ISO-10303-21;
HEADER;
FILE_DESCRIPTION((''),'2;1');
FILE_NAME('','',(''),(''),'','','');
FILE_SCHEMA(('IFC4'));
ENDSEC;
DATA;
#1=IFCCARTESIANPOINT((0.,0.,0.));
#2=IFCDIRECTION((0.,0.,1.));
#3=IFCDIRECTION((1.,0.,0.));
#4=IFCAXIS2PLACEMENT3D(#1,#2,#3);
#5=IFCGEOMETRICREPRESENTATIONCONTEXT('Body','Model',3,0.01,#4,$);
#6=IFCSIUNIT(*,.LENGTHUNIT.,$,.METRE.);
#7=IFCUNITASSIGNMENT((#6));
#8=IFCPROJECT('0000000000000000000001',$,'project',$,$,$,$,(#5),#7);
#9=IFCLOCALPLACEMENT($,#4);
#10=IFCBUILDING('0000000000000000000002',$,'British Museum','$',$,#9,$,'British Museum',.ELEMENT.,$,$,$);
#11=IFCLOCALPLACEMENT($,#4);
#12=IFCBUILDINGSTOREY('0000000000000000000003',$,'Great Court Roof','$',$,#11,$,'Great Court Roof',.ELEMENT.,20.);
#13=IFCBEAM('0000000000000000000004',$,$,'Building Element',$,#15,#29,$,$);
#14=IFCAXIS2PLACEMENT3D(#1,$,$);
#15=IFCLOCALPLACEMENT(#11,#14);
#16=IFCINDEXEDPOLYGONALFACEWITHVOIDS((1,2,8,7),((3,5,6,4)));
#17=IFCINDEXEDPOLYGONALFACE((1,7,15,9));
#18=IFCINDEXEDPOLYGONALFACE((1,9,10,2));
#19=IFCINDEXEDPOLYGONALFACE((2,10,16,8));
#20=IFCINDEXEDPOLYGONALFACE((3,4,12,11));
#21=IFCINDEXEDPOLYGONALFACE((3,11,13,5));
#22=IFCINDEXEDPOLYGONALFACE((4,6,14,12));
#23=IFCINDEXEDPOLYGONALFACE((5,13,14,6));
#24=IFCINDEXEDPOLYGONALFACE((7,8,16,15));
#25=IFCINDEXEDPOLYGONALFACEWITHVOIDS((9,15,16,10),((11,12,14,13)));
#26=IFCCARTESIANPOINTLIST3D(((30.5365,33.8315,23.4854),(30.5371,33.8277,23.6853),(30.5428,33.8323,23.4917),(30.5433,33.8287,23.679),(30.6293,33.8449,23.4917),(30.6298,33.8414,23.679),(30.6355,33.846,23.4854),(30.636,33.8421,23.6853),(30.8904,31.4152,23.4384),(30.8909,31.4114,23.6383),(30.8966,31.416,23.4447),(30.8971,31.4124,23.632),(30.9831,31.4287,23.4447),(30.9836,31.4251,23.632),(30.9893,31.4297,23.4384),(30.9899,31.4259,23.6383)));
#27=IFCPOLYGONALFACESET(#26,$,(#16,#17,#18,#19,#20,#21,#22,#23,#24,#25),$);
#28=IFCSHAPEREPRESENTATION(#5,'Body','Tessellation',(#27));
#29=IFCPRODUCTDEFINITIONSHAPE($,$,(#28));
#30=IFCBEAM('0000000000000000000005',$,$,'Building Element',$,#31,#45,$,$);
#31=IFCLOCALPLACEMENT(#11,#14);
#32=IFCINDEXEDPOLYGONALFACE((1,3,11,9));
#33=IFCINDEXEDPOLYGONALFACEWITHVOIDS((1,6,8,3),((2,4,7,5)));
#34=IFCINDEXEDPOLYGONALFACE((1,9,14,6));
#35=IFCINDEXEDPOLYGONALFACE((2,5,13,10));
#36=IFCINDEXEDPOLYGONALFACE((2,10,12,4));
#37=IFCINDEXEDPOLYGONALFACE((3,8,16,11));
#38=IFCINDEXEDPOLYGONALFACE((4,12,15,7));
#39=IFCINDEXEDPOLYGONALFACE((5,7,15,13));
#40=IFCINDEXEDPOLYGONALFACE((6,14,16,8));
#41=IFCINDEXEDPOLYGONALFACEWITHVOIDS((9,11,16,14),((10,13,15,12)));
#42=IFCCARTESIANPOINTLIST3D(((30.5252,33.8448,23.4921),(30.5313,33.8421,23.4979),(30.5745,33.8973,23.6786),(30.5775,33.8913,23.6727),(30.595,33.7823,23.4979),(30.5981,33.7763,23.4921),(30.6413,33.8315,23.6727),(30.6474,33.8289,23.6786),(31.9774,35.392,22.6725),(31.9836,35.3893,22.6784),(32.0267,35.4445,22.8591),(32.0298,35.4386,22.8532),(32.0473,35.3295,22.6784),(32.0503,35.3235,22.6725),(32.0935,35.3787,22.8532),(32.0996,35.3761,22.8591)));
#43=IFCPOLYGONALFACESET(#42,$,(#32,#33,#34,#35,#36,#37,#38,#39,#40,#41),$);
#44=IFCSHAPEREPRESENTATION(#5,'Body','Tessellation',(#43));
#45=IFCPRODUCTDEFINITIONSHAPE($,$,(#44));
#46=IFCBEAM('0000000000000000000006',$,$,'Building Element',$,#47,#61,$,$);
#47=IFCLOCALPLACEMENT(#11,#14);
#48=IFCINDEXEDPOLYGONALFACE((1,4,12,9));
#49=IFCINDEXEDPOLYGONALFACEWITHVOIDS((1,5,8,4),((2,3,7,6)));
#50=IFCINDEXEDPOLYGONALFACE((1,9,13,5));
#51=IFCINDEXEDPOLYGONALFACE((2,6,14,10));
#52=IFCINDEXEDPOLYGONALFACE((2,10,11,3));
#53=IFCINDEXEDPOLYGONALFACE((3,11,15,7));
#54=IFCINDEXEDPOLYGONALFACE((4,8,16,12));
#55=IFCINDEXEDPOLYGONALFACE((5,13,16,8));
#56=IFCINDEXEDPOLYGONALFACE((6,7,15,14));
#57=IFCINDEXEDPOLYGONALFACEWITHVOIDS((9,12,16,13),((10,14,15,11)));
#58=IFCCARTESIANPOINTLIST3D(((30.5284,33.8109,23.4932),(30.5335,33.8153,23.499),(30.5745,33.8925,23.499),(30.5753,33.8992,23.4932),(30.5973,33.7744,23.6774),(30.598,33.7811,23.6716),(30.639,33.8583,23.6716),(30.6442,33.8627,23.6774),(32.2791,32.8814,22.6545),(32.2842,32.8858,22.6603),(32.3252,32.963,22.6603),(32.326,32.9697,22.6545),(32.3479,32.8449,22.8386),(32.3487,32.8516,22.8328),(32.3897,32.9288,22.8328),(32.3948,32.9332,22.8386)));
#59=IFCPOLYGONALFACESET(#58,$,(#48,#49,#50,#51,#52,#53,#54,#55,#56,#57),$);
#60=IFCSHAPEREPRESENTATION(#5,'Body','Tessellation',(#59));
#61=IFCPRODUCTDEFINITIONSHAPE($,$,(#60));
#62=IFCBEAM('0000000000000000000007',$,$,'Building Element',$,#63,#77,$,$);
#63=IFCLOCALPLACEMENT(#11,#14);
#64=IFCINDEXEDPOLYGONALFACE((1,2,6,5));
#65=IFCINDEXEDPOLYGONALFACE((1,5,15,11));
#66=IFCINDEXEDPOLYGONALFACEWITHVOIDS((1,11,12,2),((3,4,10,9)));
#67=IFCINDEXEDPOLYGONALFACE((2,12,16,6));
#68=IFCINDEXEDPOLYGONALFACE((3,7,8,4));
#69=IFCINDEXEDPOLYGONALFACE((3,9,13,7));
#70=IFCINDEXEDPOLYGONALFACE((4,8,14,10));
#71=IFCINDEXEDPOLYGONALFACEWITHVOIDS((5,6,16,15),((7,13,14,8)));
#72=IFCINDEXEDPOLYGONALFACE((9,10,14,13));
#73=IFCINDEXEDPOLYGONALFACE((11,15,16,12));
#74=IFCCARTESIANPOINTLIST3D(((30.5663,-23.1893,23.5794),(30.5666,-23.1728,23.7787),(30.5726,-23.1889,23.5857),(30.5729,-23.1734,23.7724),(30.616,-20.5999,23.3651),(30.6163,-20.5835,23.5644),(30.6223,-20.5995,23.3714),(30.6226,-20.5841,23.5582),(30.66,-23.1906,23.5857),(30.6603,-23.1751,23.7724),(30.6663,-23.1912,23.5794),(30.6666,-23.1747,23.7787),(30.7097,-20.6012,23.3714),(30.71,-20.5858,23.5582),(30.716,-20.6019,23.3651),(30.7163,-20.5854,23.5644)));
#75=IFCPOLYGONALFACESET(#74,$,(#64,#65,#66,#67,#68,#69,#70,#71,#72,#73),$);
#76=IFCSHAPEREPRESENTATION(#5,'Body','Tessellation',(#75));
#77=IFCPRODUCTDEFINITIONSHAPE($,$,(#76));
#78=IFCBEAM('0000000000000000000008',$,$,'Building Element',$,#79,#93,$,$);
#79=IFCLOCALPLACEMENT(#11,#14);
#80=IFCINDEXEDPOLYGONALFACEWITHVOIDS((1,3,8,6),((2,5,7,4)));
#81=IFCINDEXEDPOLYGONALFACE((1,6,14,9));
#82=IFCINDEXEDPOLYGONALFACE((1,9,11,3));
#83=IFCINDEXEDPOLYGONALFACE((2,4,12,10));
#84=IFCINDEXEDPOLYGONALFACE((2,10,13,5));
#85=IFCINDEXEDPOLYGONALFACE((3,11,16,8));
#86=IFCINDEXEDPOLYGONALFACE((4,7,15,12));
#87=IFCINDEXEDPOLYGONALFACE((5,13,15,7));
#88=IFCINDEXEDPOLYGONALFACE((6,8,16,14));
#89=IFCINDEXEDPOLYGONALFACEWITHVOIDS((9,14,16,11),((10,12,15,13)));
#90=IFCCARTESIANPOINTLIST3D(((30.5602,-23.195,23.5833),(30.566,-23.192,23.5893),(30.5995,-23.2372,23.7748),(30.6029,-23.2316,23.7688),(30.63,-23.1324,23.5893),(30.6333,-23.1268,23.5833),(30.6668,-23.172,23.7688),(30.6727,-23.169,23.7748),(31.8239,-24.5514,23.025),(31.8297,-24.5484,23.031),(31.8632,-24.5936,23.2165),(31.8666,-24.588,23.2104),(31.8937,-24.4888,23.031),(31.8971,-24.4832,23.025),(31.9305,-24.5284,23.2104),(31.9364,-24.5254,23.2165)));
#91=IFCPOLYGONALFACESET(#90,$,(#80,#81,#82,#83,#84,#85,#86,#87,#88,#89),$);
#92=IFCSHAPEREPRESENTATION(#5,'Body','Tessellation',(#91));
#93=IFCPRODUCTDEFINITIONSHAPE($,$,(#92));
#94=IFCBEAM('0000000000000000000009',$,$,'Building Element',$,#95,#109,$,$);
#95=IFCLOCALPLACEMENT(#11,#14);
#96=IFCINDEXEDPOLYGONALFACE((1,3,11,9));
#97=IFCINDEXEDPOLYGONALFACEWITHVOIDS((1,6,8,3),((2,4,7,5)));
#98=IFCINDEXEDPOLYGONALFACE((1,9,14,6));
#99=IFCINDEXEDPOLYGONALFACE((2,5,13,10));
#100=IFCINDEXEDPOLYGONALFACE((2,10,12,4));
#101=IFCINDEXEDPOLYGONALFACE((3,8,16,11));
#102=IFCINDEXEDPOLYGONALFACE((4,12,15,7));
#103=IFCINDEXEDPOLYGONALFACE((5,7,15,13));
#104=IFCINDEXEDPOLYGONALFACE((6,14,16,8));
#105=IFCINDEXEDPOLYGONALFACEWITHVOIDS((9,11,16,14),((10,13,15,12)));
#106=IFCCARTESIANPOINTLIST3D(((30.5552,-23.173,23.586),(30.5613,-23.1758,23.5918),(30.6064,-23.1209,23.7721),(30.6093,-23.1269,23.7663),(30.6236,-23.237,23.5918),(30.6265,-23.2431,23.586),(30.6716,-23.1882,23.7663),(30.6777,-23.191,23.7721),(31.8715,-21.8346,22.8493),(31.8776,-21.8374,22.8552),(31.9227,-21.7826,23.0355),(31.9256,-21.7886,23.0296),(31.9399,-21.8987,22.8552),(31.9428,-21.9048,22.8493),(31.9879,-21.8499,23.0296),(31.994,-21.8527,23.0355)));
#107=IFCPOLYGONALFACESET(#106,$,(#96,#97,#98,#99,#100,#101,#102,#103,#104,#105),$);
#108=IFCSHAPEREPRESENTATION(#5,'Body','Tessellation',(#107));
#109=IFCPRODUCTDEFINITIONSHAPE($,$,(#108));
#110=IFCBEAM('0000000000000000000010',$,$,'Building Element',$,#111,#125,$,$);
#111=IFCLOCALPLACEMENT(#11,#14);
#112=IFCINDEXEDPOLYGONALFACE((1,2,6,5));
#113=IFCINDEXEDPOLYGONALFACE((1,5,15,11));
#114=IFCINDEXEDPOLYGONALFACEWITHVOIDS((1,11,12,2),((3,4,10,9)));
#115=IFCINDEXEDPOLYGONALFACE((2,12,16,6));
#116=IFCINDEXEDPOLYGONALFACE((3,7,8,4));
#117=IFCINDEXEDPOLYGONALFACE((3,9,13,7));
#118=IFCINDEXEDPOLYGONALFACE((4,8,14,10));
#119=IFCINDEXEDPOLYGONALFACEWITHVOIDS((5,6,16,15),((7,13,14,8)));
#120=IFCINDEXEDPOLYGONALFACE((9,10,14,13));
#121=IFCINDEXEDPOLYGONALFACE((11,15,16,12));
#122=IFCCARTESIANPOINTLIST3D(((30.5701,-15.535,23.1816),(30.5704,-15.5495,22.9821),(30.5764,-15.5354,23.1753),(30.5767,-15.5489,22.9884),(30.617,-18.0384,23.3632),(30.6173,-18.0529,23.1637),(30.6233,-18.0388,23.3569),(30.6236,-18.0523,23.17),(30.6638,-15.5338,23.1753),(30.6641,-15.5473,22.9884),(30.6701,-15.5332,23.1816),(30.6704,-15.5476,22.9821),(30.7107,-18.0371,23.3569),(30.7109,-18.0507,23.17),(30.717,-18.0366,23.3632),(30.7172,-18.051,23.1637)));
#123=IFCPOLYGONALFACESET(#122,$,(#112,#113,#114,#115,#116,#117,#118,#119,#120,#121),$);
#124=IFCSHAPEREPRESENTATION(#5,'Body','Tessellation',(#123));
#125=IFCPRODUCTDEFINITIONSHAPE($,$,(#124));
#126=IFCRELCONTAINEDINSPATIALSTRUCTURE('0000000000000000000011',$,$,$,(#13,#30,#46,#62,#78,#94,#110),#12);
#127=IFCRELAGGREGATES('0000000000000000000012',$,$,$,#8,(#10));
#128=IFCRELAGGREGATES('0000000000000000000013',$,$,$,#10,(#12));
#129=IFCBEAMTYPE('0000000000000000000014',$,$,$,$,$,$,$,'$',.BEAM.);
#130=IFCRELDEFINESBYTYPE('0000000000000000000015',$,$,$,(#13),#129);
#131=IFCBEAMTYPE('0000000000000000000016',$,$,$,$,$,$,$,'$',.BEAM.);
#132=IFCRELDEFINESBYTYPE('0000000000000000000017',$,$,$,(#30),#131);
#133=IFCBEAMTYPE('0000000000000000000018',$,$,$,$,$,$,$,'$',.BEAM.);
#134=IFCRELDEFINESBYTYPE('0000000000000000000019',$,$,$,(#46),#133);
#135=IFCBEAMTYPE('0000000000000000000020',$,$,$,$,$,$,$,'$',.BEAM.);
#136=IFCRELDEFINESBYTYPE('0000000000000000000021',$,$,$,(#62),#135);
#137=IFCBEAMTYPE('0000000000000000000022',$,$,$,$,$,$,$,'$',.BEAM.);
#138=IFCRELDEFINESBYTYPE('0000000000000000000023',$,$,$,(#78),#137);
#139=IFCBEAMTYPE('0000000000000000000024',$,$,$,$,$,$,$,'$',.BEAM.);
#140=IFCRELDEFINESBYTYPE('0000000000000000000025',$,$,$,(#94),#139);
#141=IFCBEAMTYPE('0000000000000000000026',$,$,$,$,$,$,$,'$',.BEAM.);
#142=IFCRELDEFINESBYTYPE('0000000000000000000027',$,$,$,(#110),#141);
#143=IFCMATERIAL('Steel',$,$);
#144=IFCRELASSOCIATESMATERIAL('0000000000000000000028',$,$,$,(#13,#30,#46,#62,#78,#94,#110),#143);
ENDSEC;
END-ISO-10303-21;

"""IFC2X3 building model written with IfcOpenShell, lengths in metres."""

from ifc_helpers import new_model, si_unit, frame, origin_with_axes, origin_2d, place, context, project, spatial, hollow_rectangle, extrude, material, type_object, element, save


model = new_model("IFC2X3")

# Units and contexts
model_context = context("Model", 3, precision=0.01, world=origin_with_axes(), identifier="Body")
ifc_project = project(units=[si_unit("LENGTHUNIT", "METRE")], contexts=[model_context])

# Building, storey
building_placement = place(None, origin_with_axes())
building = spatial("IfcBuilding", under=ifc_project, at=building_placement, Name="British Museum", Description="$", LongName="British Museum", CompositionType="ELEMENT")
storey_placement = place(None, origin_with_axes())
storey = spatial("IfcBuildingStorey", under=building, at=storey_placement, Name="Great Court Roof", Description="$", LongName="Great Court Roof", CompositionType="ELEMENT", Elevation=20.0)

# Beams
ifc_material = material(Name="Steel")
beam_type_1 = type_object("IfcBeamType", ElementType="$", PredefinedType="BEAM")
beam_1_placement = place(None, origin_with_axes())
element("IfcBeam", 1, at=beam_1_placement, inside=storey, type_object=beam_type_1, material=ifc_material, Description="Building Element", context=model_context, shape_type="SweptSolid", body=[
    extrude(hollow_rectangle(XDim=0.1, YDim=0.2, WallThickness=0.0063, InnerFilletRadius=-0.0063, OuterFilletRadius=0.0, at=origin_2d()), frame((30.5863, 33.8368, 23.5853), z_axis=(0.144869, -0.989264, -0.019237), x_axis=(0.989447, 0.144895, 0.0)), (0.0, 0.0, 1.0), 2.4425),
])
beam_type_2 = type_object("IfcBeamType", ElementType="$", PredefinedType="BEAM")
beam_2_placement = place(None, origin_with_axes())
element("IfcBeam", 2, at=beam_2_placement, inside=storey, type_object=beam_type_2, material=ifc_material, Description="Building Element", context=model_context, shape_type="SweptSolid", body=[
    extrude(hollow_rectangle(XDim=0.1, YDim=0.2, WallThickness=0.0063, InnerFilletRadius=-0.0063, OuterFilletRadius=0.0, at=origin_2d()), frame((30.5863, 33.8368, 23.5853), z_axis=(0.638415, 0.680173, -0.360265), x_axis=(-0.729134, 0.684371, 0.0)), (0.0, 0.0, 1.0), 2.2748),
])
beam_type_3 = type_object("IfcBeamType", ElementType="$", PredefinedType="BEAM")
beam_3_placement = place(None, origin_with_axes())
element("IfcBeam", 3, at=beam_3_placement, inside=storey, type_object=beam_type_3, material=ifc_material, Description="Building Element", context=model_context, shape_type="SweptSolid", body=[
    extrude(hollow_rectangle(XDim=0.1, YDim=0.2, WallThickness=0.0063, InnerFilletRadius=-0.0063, OuterFilletRadius=0.0, at=origin_2d()), frame((30.5863, 33.8368, 23.5853), z_axis=(0.813388, -0.431876, -0.389722), x_axis=(0.468955, 0.883222, 0.0)), (0.0, 0.0, 1.0), 2.1523),
])
beam_type_4 = type_object("IfcBeamType", ElementType="$", PredefinedType="BEAM")
beam_4_placement = place(None, origin_with_axes())
element("IfcBeam", 4, at=beam_4_placement, inside=storey, type_object=beam_type_4, material=ifc_material, Description="Building Element", context=model_context, shape_type="SweptSolid", body=[
    extrude(hollow_rectangle(XDim=0.1, YDim=0.2, WallThickness=0.0063, InnerFilletRadius=-0.0063, OuterFilletRadius=0.0, at=origin_2d()), frame((30.6164, -23.182, 23.679), z_axis=(0.019133, 0.996412, -0.082448), x_axis=(-0.999816, 0.019198, 0.0)), (0.0, 0.0, 1.0), 2.5987),
])
beam_type_5 = type_object("IfcBeamType", ElementType="$", PredefinedType="BEAM")
beam_5_placement = place(None, origin_with_axes())
element("IfcBeam", 5, at=beam_5_placement, inside=storey, type_object=beam_type_5, material=ifc_material, Description="Building Element", context=model_context, shape_type="SweptSolid", body=[
    extrude(hollow_rectangle(XDim=0.1, YDim=0.2, WallThickness=0.0063, InnerFilletRadius=-0.0063, OuterFilletRadius=0.0, at=origin_2d()), frame((30.6164, -23.182, 23.679), z_axis=(0.652708, -0.700582, -0.288369), x_axis=(0.731664, 0.681666, 0.0)), (0.0, 0.0, 1.0), 1.9361),
])
beam_type_6 = type_object("IfcBeamType", ElementType="$", PredefinedType="BEAM")
beam_6_placement = place(None, origin_with_axes())
element("IfcBeam", 6, at=beam_6_placement, inside=storey, type_object=beam_type_6, material=ifc_material, Description="Building Element", context=model_context, shape_type="SweptSolid", body=[
    extrude(hollow_rectangle(XDim=0.1, YDim=0.2, WallThickness=0.0063, InnerFilletRadius=-0.0063, OuterFilletRadius=0.0, at=origin_2d()), frame((30.6164, -23.182, 23.679), z_axis=(0.65276, 0.663671, -0.365303), x_axis=(-0.712943, 0.701222, 0.0)), (0.0, 0.0, 1.0), 2.0166),
])
beam_type_7 = type_object("IfcBeamType", ElementType="$", PredefinedType="BEAM")
beam_7_placement = place(None, origin_with_axes())
element("IfcBeam", 7, at=beam_7_placement, inside=storey, type_object=beam_type_7, material=ifc_material, Description="Building Element", context=model_context, shape_type="SweptSolid", body=[
    extrude(hollow_rectangle(XDim=0.1, YDim=0.2, WallThickness=0.0063, InnerFilletRadius=-0.0063, OuterFilletRadius=0.0, at=origin_2d()), frame((30.6202, -15.5413, 23.0818), z_axis=(0.018675, -0.997206, 0.072335), x_axis=(0.999825, 0.018724, 0.0)), (0.0, 0.0, 1.0), 2.5104),
])

save(model, "model.ifc")
